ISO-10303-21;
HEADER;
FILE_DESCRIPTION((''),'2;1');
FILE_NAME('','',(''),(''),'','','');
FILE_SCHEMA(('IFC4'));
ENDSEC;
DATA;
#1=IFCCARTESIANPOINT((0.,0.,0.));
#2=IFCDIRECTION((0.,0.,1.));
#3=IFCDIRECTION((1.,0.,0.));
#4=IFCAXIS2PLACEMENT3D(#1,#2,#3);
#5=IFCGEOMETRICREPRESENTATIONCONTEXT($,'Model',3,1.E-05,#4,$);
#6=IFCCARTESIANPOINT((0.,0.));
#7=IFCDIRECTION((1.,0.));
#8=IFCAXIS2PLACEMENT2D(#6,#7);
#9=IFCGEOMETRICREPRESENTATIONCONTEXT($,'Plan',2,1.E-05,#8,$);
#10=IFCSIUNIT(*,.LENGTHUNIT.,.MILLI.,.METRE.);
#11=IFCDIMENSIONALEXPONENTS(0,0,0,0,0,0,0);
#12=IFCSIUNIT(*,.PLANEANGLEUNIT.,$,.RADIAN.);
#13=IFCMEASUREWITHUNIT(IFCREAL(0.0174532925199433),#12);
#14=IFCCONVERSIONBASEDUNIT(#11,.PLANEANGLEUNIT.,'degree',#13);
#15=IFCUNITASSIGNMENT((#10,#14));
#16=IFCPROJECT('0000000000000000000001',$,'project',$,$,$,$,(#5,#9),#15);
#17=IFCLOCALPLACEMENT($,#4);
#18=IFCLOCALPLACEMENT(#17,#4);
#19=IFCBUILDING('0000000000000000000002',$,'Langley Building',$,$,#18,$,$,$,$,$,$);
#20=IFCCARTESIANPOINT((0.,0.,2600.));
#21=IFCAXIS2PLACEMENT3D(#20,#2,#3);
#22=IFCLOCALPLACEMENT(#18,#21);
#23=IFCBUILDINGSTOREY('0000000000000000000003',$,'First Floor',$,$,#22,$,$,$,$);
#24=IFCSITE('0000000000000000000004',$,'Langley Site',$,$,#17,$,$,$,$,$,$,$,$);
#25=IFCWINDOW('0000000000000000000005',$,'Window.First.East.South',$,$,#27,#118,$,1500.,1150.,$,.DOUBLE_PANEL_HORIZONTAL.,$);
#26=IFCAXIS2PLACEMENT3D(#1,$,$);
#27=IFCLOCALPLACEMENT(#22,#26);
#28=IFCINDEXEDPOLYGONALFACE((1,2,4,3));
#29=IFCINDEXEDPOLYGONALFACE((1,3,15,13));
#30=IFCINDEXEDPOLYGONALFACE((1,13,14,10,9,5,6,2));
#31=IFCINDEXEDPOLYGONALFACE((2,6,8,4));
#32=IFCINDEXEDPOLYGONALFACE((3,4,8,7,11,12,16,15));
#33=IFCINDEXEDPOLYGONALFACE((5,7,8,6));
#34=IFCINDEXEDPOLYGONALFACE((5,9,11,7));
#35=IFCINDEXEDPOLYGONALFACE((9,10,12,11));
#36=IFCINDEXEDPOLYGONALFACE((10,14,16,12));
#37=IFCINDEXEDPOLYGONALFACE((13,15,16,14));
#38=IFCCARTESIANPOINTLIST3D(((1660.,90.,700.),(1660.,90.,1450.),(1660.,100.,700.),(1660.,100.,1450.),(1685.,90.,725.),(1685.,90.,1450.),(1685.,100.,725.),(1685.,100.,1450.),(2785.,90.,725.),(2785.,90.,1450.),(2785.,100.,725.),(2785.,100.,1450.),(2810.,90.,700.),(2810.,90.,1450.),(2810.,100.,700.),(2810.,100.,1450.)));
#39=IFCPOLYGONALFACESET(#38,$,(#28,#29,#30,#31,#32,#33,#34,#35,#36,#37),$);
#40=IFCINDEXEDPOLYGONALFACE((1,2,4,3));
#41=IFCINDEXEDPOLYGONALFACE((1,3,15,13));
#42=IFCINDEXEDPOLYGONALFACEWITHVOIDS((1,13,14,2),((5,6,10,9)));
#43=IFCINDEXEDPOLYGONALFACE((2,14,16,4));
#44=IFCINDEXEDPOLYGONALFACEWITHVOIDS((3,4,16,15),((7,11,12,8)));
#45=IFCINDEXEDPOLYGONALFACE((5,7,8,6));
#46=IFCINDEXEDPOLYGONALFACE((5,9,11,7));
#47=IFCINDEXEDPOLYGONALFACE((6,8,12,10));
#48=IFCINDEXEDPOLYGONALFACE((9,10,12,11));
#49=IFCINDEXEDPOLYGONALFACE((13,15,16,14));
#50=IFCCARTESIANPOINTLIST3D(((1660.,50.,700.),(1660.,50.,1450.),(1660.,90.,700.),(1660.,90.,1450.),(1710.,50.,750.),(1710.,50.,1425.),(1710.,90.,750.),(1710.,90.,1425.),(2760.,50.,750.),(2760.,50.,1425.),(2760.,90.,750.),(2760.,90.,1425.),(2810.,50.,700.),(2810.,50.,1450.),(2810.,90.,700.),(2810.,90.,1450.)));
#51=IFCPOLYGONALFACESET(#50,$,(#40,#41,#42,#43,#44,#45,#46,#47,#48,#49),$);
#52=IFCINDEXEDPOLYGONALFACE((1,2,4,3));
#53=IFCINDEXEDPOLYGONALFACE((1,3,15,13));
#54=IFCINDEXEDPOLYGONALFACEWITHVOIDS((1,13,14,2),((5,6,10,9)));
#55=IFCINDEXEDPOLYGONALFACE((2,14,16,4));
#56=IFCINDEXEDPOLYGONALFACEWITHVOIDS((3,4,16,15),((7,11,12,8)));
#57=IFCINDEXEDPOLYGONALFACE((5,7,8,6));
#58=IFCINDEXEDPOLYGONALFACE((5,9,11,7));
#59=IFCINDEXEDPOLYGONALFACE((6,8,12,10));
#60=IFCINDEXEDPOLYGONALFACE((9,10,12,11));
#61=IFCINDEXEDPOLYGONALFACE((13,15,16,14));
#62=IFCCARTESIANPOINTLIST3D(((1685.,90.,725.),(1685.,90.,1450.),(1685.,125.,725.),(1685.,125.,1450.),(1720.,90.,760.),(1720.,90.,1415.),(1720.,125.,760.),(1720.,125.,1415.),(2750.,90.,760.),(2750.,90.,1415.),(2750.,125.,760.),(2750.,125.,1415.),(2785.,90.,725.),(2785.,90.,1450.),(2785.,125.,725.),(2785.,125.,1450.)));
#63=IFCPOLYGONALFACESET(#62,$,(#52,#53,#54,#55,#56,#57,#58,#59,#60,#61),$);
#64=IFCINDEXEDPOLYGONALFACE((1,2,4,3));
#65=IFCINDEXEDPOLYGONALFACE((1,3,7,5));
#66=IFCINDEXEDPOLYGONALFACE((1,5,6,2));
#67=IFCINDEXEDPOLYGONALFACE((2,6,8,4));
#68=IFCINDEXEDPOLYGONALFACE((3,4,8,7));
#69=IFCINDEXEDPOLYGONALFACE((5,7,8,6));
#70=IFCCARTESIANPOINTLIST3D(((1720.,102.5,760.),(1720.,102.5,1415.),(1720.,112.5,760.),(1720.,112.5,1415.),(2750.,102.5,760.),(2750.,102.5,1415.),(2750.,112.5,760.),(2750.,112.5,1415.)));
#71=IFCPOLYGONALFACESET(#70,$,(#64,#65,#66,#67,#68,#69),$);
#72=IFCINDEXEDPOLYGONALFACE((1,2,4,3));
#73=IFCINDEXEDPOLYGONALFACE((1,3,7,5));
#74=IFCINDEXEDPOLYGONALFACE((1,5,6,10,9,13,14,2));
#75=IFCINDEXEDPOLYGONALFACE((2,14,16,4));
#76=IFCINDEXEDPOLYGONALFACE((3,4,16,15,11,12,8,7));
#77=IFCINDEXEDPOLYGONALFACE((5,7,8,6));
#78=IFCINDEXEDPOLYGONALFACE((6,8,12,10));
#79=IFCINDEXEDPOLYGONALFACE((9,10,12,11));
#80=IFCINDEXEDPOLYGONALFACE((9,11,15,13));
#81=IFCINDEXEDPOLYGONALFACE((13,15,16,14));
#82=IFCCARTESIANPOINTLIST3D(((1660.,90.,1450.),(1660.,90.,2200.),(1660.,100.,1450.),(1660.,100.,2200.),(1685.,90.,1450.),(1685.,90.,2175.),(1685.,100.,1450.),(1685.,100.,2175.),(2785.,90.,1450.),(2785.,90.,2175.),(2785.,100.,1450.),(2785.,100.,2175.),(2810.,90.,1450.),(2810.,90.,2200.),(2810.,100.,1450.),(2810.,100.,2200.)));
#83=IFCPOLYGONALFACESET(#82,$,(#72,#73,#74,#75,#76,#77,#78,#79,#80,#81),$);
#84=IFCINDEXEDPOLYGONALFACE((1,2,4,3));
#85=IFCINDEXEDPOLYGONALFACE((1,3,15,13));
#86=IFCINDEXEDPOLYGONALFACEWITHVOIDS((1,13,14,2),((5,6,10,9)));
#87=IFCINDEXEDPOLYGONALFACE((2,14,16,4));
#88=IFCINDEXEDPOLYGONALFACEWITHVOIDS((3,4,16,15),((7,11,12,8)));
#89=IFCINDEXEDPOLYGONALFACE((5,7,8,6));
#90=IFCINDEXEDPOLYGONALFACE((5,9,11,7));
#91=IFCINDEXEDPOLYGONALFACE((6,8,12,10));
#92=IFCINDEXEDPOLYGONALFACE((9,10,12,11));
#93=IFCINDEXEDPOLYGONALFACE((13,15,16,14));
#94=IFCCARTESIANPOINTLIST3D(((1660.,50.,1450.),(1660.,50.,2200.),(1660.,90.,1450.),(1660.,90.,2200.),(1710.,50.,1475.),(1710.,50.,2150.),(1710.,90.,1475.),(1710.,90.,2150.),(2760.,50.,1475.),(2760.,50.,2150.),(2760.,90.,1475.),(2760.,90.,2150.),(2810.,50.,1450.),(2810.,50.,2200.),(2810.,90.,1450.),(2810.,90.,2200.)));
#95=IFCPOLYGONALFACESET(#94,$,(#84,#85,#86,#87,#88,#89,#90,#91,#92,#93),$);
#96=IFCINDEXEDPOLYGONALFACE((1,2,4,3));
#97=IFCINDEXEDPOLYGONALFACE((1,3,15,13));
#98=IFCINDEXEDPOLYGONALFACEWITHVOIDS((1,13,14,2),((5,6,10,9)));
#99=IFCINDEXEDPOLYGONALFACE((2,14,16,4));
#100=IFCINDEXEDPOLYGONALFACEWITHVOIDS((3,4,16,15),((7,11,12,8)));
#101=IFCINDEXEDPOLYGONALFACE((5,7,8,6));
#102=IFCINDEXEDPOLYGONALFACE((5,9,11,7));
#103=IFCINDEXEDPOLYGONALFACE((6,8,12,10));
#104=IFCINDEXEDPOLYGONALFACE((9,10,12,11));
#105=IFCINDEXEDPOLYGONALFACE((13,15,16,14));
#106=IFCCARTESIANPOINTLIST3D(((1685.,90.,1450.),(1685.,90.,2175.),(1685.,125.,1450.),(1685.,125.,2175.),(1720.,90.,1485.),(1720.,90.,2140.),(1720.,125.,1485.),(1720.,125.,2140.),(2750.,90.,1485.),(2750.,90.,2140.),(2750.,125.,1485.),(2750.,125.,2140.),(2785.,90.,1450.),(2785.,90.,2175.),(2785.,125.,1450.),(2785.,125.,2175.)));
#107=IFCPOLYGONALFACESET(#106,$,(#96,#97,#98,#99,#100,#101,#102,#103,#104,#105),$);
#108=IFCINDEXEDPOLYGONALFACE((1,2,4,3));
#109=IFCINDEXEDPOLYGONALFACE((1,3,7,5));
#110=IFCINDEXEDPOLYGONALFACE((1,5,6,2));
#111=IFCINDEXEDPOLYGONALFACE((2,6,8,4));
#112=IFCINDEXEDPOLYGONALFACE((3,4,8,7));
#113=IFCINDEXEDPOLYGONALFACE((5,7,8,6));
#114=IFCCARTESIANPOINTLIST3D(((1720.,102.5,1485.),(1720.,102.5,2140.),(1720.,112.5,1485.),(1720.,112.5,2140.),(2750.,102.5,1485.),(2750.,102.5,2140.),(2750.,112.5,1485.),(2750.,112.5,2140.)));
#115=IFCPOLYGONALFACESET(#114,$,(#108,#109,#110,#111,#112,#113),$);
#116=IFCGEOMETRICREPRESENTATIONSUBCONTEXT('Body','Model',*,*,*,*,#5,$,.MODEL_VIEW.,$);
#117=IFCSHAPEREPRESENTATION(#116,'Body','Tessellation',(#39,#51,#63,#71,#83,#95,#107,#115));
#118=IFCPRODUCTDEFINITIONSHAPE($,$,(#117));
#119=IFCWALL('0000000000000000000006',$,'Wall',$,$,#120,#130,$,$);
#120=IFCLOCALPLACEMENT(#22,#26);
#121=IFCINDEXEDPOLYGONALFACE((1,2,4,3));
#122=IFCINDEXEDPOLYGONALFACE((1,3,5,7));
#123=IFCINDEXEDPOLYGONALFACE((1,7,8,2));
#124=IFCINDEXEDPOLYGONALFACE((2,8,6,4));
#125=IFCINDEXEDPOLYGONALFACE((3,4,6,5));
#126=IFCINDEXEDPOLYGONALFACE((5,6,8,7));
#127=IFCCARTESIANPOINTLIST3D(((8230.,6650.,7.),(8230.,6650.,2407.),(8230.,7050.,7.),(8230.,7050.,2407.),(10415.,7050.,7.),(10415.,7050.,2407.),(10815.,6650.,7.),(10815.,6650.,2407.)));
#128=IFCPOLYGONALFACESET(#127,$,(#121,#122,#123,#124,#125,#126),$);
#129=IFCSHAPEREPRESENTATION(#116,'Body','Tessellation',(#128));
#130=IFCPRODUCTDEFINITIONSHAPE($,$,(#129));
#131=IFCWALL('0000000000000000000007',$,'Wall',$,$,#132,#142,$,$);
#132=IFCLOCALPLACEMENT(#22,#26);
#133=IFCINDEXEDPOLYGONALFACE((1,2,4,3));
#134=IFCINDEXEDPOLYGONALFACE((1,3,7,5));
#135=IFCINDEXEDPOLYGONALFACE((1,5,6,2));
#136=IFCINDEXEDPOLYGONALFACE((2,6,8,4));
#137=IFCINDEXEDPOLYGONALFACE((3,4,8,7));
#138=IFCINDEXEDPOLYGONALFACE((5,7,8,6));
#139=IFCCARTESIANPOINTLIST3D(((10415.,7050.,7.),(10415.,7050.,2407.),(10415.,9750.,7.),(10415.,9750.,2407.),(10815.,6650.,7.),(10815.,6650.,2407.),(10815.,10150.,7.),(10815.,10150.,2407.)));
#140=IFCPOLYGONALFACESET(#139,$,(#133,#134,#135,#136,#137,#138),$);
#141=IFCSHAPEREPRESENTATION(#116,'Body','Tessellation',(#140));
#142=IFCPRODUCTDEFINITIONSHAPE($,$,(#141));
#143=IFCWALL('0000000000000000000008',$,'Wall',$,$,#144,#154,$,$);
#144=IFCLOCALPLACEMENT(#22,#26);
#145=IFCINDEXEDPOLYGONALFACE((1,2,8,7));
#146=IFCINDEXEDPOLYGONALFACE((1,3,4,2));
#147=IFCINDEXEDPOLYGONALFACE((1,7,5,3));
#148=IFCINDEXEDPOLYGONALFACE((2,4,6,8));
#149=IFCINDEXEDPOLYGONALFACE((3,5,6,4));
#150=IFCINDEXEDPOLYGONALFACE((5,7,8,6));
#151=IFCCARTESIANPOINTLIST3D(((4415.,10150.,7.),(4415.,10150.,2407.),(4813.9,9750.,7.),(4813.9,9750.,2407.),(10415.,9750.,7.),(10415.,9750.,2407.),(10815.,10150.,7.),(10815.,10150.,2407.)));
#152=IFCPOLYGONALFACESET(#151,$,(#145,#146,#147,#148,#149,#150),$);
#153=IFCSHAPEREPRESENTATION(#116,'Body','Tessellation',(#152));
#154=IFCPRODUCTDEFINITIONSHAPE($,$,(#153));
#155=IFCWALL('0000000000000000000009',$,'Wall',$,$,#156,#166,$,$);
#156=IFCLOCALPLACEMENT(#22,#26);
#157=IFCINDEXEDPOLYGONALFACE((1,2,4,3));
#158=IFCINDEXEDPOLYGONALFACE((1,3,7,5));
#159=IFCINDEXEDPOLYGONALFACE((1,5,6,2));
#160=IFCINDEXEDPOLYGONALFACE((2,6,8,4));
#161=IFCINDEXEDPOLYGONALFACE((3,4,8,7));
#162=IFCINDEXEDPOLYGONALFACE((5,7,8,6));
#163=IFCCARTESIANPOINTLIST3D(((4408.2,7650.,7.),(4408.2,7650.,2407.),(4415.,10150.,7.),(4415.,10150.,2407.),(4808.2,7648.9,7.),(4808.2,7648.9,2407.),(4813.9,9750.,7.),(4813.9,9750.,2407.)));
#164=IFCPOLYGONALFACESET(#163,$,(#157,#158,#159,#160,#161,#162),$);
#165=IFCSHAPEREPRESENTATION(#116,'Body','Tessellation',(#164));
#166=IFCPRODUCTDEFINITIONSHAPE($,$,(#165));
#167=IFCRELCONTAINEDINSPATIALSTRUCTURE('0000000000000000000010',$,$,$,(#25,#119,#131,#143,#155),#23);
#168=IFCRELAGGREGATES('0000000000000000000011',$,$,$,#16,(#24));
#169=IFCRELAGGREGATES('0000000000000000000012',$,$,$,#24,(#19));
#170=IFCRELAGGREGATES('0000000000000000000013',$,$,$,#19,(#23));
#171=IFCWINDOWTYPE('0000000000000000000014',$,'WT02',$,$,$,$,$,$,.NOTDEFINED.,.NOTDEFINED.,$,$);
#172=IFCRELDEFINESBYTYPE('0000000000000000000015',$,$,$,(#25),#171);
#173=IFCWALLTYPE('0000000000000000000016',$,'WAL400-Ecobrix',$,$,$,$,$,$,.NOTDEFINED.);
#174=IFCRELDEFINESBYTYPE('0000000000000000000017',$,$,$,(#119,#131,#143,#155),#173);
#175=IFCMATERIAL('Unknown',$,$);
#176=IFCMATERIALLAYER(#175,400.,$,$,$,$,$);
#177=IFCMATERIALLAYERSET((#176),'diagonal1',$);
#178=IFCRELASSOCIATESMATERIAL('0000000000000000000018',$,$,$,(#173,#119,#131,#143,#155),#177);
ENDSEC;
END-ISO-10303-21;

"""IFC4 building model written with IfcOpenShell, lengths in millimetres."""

from ifc_helpers import new_model, entity, si_unit, converted_unit, frame, origin_with_axes, origin_2d_with_axis, place, context, subcontext, project, spatial, line, indexed_curve, outline, extrude, shape, source, transform, mapped, material, layer, layer_set, layer_usage, type_object, type_shapes, element, save


model = new_model("IFC4")

# Units and contexts
model_context = context("Model", 3, precision=1e-05, world=origin_with_axes())
plan_context = context("Plan", 2, precision=1e-05, world=origin_2d_with_axis())
body_context_1 = subcontext(model_context, "Body", "Model", "MODEL_VIEW")
body_context_2 = subcontext(plan_context, "Body", "Plan", "PLAN_VIEW")
ifc_project = project(units=[si_unit("LENGTHUNIT", "METRE", prefix="MILLI"), converted_unit("PLANEANGLEUNIT", "degree", entity("IfcReal", 0.0174532925199433), si_unit("PLANEANGLEUNIT", "RADIAN"), dimensions=[0, 0, 0, 0, 0, 0, 0])], contexts=[model_context, plan_context])

# Site, building, storey
site_placement = place(None, origin_with_axes())
site = spatial("IfcSite", under=ifc_project, at=site_placement, Name="Langley Site")
building_placement = place(site_placement, origin_with_axes())
building = spatial("IfcBuilding", under=site, at=building_placement, Name="Langley Building")
storey_placement = place(building_placement, frame((0.0, 0.0, 2600.0), z_axis=(0.0, 0.0, 1.0), x_axis=(1.0, 0.0, 0.0)))
storey = spatial("IfcBuildingStorey", under=building, at=storey_placement, Name="First Floor")

# Shared definitions
ifc_material = material(Name="Unknown")

# Window
window_type_1 = type_object("IfcWindowType", Name="WT02", PartitioningType="NOTDEFINED", PredefinedType="NOTDEFINED")
shared_shape_1 = source(origin_with_axes(), body_context_1, "Body", "SweptSolid", [
    extrude(outline(indexed_curve([(1150.0, 750.0), (1150.0, 0.0), (0.0, 0.0), (0.0, 750.0), (25.0, 750.0), (25.0, 25.0), (1125.0, 25.0), (1125.0, 750.0)], segments=[line(1, 2, 3, 4, 5, 6, 7, 8, 1)])), frame((0.0, 90.0, 0.0), z_axis=(0.0, -1.0, 0.0), x_axis=(1.0, 0.0, 0.0)), (0.0, 0.0, -1.0), 10.0),
    extrude(outline(indexed_curve([(0.0, 0.0), (1150.0, 0.0), (1150.0, 750.0), (0.0, 750.0)], segments=[line(1, 2, 3, 4, 1)]), holes=[indexed_curve([(50.0, 50.0), (1100.0, 50.0), (1100.0, 725.0), (50.0, 725.0)], segments=[line(1, 2, 3, 4, 1)])]), frame((0.0, 50.0, 0.0), z_axis=(0.0, -1.0, 0.0), x_axis=(1.0, 0.0, 0.0)), (0.0, 0.0, -1.0), 40.0),
    extrude(outline(indexed_curve([(0.0, 0.0), (1100.0, 0.0), (1100.0, 725.0), (0.0, 725.0)], segments=[line(1, 2, 3, 4, 1)]), holes=[indexed_curve([(35.0, 35.0), (1065.0, 35.0), (1065.0, 690.0), (35.0, 690.0)], segments=[line(1, 2, 3, 4, 1)])]), frame((25.0, 90.0, 25.0), z_axis=(0.0, -1.0, 0.0), x_axis=(1.0, 0.0, 0.0)), (0.0, 0.0, -1.0), 35.0),
    extrude(outline(indexed_curve([(35.0, 35.0), (1065.0, 35.0), (1065.0, 690.0), (35.0, 690.0)], segments=[line(1, 2, 3, 4, 1)])), frame((25.0, 102.5, 25.0), z_axis=(0.0, -1.0, 0.0), x_axis=(1.0, 0.0, 0.0)), (0.0, 0.0, -1.0), 10.0),
    extrude(outline(indexed_curve([(0.0, 0.0), (0.0, 750.0), (1150.0, 750.0), (1150.0, 0.0), (1125.0, 0.0), (1125.0, 725.0), (25.0, 725.0), (25.0, 0.0)], segments=[line(1, 2, 3, 4, 5, 6, 7, 8, 1)])), frame((0.0, 90.0, 750.0), z_axis=(0.0, -1.0, 0.0), x_axis=(1.0, 0.0, 0.0)), (0.0, 0.0, -1.0), 10.0),
    extrude(outline(indexed_curve([(0.0, 0.0), (1150.0, 0.0), (1150.0, 750.0), (0.0, 750.0)], segments=[line(1, 2, 3, 4, 1)]), holes=[indexed_curve([(50.0, 25.0), (1100.0, 25.0), (1100.0, 700.0), (50.0, 700.0)], segments=[line(1, 2, 3, 4, 1)])]), frame((0.0, 50.0, 750.0), z_axis=(0.0, -1.0, 0.0), x_axis=(1.0, 0.0, 0.0)), (0.0, 0.0, -1.0), 40.0),
    extrude(outline(indexed_curve([(0.0, 0.0), (1100.0, 0.0), (1100.0, 725.0), (0.0, 725.0)], segments=[line(1, 2, 3, 4, 1)]), holes=[indexed_curve([(35.0, 35.0), (1065.0, 35.0), (1065.0, 690.0), (35.0, 690.0)], segments=[line(1, 2, 3, 4, 1)])]), frame((25.0, 90.0, 750.0), z_axis=(0.0, -1.0, 0.0), x_axis=(1.0, 0.0, 0.0)), (0.0, 0.0, -1.0), 35.0),
    extrude(outline(indexed_curve([(35.0, 35.0), (1065.0, 35.0), (1065.0, 690.0), (35.0, 690.0)], segments=[line(1, 2, 3, 4, 1)])), frame((25.0, 102.5, 750.0), z_axis=(0.0, -1.0, 0.0), x_axis=(1.0, 0.0, 0.0)), (0.0, 0.0, -1.0), 10.0),
])
shared_shape_2 = source(origin_with_axes(), body_context_2, "Body", "Curve2D", [
    entity("IfcIndexedPolyCurve", entity("IfcCartesianPointList2D", [[50.0, 50.0], [1100.0, 50.0]])),
    entity("IfcIndexedPolyCurve", entity("IfcCartesianPointList2D", [[0.0, 100.0], [25.0, 100.0], [25.0, 90.0], [50.0, 90.0], [50.0, 50.0], [0.0, 50.0]]), [entity("IfcLineIndex", [1, 2, 3, 4, 5, 6, 1])]),
    entity("IfcIndexedPolyCurve", entity("IfcCartesianPointList2D", [[1150.0, 100.0], [1125.0, 100.0], [1125.0, 90.0], [1100.0, 90.0], [1100.0, 50.0], [1150.0, 50.0]]), [entity("IfcLineIndex", [1, 2, 3, 4, 5, 6, 1])]),
    entity("IfcIndexedPolyCurve", entity("IfcCartesianPointList2D", [[25.0, 90.0], [60.0, 90.0], [60.0, 125.0], [25.0, 125.0]]), [entity("IfcLineIndex", [1, 2, 3, 4, 1])]),
    entity("IfcIndexedPolyCurve", entity("IfcCartesianPointList2D", [[1125.0, 90.0], [1090.0, 90.0], [1090.0, 125.0], [1125.0, 125.0]]), [entity("IfcLineIndex", [1, 2, 3, 4, 1])]),
    entity("IfcIndexedPolyCurve", entity("IfcCartesianPointList2D", [[60.0, 90.0], [1090.0, 90.0]])),
    entity("IfcIndexedPolyCurve", entity("IfcCartesianPointList2D", [[60.0, 125.0], [1090.0, 125.0]])),
    entity("IfcIndexedPolyCurve", entity("IfcCartesianPointList2D", [[60.0, 107.5], [1090.0, 107.5]])),
])
type_shapes(window_type_1, [shared_shape_1, shared_shape_2])
for number, where, z_axis, x_axis, name in (
    (1, (1660.0, 0.0, 700.0), (0.0, 0.0, 1.0), (1.0, 0.0, 0.0), "Window.First.East.South"),
):
    element("IfcWindow", number, at=place(storey_placement, frame(where, z_axis=z_axis, x_axis=x_axis)), inside=storey, type_object=window_type_1, Name=name, OverallHeight=1500.0, OverallWidth=1150.0, PartitioningType="DOUBLE_PANEL_HORIZONTAL", shapes=[
        shape(body_context_1, "Body", "MappedRepresentation", [mapped(shared_shape_1, transform((0.0, 0.0, 0.0), x_axis=(1.0, 0.0, 0.0), y_axis=(0.0, 1.0, 0.0), z_axis=(0.0, 0.0, 1.0), scale=1.0))]),
        shape(body_context_2, "Body", "MappedRepresentation", [mapped(shared_shape_2, transform((0.0, 0.0, 0.0), x_axis=(1.0, 0.0, 0.0), y_axis=(0.0, 1.0, 0.0), z_axis=(0.0, 0.0, 1.0), scale=1.0))]),
    ])

# Walls
ifc_layer_1 = layer(ifc_material, 400.0)
ifc_layer_set_1 = layer_set([ifc_layer_1], Name="diagonal1")
ifc_layer_usage_1 = layer_usage(ifc_layer_set_1, "AXIS2", "POSITIVE", 0.0)
wall_type_1 = type_object("IfcWallType", Name="WAL400-Ecobrix", PredefinedType="NOTDEFINED", material=ifc_layer_set_1)
wall_1_placement = place(storey_placement, frame((8230.0, 6650.0, 7.0), z_axis=(0.0, 0.0, 1.0), x_axis=(1.0, 0.0, 0.0)))
element("IfcWall", 2, at=wall_1_placement, inside=storey, type_object=wall_type_1, material=ifc_layer_usage_1, Name="Wall", context=body_context_1, shape_type="SweptSolid", body=[
    extrude(outline(indexed_curve([(0.0, 0.0), (0.0, 400.0), (2185.0, 400.0), (2585.0, 0.0)], segments=[line(1, 2, 3, 4, 1)])), origin_with_axes(), (0.0, 0.0, 1.0), 2400.0),
])
ifc_layer_usage_2 = layer_usage(ifc_layer_set_1, "AXIS2", "POSITIVE", 0.0)
wall_2_placement = place(storey_placement, frame((10815.0, 6650.0, 7.0), z_axis=(0.0, 0.0, 1.0), x_axis=(0.0, 1.0, 0.0)))
element("IfcWall", 3, at=wall_2_placement, inside=storey, type_object=wall_type_1, material=ifc_layer_usage_2, Name="Wall", context=body_context_1, shape_type="SweptSolid", body=[
    extrude(outline(indexed_curve([(0.0, 0.0), (400.0, 400.0), (3100.0, 400.0), (3500.0, 0.0)], segments=[line(1, 2, 3, 4, 1)])), origin_with_axes(), (0.0, 0.0, 1.0), 2400.0),
])
ifc_layer_usage_3 = layer_usage(ifc_layer_set_1, "AXIS2", "POSITIVE", 0.0)
wall_3_placement = place(storey_placement, frame((10815.0, 10150.0, 7.0), z_axis=(0.0, 0.0, 1.0), x_axis=(-1.0, 0.0, 0.0)))
element("IfcWall", 4, at=wall_3_placement, inside=storey, type_object=wall_type_1, material=ifc_layer_usage_3, Name="Wall", context=body_context_1, shape_type="SweptSolid", body=[
    extrude(outline(indexed_curve([(0.0, 0.0), (400.0, 400.0), (6001.1, 400.0), (6400.0, 0.0)], segments=[line(1, 2, 3, 4, 1)])), origin_with_axes(), (0.0, 0.0, 1.0), 2400.0),
])
ifc_layer_usage_4 = layer_usage(ifc_layer_set_1, "AXIS2", "POSITIVE", 0.0)
wall_4_placement = place(storey_placement, frame((4415.0, 10150.0, 7.0), z_axis=(0.0, 0.0, 1.0), x_axis=(-0.002716, -0.999996, 0.0)))
element("IfcWall", 5, at=wall_4_placement, inside=storey, type_object=wall_type_1, material=ifc_layer_usage_4, Name="Wall", context=body_context_1, shape_type="SweptSolid", body=[
    extrude(outline(indexed_curve([(0.0, 0.0), (398.9, 400.0), (2500.0, 400.0), (2500.0, 0.0)], segments=[line(1, 2, 3, 4, 1)])), origin_with_axes(), (0.0, 0.0, 1.0), 2400.0),
])

save(model, "model.ifc")
